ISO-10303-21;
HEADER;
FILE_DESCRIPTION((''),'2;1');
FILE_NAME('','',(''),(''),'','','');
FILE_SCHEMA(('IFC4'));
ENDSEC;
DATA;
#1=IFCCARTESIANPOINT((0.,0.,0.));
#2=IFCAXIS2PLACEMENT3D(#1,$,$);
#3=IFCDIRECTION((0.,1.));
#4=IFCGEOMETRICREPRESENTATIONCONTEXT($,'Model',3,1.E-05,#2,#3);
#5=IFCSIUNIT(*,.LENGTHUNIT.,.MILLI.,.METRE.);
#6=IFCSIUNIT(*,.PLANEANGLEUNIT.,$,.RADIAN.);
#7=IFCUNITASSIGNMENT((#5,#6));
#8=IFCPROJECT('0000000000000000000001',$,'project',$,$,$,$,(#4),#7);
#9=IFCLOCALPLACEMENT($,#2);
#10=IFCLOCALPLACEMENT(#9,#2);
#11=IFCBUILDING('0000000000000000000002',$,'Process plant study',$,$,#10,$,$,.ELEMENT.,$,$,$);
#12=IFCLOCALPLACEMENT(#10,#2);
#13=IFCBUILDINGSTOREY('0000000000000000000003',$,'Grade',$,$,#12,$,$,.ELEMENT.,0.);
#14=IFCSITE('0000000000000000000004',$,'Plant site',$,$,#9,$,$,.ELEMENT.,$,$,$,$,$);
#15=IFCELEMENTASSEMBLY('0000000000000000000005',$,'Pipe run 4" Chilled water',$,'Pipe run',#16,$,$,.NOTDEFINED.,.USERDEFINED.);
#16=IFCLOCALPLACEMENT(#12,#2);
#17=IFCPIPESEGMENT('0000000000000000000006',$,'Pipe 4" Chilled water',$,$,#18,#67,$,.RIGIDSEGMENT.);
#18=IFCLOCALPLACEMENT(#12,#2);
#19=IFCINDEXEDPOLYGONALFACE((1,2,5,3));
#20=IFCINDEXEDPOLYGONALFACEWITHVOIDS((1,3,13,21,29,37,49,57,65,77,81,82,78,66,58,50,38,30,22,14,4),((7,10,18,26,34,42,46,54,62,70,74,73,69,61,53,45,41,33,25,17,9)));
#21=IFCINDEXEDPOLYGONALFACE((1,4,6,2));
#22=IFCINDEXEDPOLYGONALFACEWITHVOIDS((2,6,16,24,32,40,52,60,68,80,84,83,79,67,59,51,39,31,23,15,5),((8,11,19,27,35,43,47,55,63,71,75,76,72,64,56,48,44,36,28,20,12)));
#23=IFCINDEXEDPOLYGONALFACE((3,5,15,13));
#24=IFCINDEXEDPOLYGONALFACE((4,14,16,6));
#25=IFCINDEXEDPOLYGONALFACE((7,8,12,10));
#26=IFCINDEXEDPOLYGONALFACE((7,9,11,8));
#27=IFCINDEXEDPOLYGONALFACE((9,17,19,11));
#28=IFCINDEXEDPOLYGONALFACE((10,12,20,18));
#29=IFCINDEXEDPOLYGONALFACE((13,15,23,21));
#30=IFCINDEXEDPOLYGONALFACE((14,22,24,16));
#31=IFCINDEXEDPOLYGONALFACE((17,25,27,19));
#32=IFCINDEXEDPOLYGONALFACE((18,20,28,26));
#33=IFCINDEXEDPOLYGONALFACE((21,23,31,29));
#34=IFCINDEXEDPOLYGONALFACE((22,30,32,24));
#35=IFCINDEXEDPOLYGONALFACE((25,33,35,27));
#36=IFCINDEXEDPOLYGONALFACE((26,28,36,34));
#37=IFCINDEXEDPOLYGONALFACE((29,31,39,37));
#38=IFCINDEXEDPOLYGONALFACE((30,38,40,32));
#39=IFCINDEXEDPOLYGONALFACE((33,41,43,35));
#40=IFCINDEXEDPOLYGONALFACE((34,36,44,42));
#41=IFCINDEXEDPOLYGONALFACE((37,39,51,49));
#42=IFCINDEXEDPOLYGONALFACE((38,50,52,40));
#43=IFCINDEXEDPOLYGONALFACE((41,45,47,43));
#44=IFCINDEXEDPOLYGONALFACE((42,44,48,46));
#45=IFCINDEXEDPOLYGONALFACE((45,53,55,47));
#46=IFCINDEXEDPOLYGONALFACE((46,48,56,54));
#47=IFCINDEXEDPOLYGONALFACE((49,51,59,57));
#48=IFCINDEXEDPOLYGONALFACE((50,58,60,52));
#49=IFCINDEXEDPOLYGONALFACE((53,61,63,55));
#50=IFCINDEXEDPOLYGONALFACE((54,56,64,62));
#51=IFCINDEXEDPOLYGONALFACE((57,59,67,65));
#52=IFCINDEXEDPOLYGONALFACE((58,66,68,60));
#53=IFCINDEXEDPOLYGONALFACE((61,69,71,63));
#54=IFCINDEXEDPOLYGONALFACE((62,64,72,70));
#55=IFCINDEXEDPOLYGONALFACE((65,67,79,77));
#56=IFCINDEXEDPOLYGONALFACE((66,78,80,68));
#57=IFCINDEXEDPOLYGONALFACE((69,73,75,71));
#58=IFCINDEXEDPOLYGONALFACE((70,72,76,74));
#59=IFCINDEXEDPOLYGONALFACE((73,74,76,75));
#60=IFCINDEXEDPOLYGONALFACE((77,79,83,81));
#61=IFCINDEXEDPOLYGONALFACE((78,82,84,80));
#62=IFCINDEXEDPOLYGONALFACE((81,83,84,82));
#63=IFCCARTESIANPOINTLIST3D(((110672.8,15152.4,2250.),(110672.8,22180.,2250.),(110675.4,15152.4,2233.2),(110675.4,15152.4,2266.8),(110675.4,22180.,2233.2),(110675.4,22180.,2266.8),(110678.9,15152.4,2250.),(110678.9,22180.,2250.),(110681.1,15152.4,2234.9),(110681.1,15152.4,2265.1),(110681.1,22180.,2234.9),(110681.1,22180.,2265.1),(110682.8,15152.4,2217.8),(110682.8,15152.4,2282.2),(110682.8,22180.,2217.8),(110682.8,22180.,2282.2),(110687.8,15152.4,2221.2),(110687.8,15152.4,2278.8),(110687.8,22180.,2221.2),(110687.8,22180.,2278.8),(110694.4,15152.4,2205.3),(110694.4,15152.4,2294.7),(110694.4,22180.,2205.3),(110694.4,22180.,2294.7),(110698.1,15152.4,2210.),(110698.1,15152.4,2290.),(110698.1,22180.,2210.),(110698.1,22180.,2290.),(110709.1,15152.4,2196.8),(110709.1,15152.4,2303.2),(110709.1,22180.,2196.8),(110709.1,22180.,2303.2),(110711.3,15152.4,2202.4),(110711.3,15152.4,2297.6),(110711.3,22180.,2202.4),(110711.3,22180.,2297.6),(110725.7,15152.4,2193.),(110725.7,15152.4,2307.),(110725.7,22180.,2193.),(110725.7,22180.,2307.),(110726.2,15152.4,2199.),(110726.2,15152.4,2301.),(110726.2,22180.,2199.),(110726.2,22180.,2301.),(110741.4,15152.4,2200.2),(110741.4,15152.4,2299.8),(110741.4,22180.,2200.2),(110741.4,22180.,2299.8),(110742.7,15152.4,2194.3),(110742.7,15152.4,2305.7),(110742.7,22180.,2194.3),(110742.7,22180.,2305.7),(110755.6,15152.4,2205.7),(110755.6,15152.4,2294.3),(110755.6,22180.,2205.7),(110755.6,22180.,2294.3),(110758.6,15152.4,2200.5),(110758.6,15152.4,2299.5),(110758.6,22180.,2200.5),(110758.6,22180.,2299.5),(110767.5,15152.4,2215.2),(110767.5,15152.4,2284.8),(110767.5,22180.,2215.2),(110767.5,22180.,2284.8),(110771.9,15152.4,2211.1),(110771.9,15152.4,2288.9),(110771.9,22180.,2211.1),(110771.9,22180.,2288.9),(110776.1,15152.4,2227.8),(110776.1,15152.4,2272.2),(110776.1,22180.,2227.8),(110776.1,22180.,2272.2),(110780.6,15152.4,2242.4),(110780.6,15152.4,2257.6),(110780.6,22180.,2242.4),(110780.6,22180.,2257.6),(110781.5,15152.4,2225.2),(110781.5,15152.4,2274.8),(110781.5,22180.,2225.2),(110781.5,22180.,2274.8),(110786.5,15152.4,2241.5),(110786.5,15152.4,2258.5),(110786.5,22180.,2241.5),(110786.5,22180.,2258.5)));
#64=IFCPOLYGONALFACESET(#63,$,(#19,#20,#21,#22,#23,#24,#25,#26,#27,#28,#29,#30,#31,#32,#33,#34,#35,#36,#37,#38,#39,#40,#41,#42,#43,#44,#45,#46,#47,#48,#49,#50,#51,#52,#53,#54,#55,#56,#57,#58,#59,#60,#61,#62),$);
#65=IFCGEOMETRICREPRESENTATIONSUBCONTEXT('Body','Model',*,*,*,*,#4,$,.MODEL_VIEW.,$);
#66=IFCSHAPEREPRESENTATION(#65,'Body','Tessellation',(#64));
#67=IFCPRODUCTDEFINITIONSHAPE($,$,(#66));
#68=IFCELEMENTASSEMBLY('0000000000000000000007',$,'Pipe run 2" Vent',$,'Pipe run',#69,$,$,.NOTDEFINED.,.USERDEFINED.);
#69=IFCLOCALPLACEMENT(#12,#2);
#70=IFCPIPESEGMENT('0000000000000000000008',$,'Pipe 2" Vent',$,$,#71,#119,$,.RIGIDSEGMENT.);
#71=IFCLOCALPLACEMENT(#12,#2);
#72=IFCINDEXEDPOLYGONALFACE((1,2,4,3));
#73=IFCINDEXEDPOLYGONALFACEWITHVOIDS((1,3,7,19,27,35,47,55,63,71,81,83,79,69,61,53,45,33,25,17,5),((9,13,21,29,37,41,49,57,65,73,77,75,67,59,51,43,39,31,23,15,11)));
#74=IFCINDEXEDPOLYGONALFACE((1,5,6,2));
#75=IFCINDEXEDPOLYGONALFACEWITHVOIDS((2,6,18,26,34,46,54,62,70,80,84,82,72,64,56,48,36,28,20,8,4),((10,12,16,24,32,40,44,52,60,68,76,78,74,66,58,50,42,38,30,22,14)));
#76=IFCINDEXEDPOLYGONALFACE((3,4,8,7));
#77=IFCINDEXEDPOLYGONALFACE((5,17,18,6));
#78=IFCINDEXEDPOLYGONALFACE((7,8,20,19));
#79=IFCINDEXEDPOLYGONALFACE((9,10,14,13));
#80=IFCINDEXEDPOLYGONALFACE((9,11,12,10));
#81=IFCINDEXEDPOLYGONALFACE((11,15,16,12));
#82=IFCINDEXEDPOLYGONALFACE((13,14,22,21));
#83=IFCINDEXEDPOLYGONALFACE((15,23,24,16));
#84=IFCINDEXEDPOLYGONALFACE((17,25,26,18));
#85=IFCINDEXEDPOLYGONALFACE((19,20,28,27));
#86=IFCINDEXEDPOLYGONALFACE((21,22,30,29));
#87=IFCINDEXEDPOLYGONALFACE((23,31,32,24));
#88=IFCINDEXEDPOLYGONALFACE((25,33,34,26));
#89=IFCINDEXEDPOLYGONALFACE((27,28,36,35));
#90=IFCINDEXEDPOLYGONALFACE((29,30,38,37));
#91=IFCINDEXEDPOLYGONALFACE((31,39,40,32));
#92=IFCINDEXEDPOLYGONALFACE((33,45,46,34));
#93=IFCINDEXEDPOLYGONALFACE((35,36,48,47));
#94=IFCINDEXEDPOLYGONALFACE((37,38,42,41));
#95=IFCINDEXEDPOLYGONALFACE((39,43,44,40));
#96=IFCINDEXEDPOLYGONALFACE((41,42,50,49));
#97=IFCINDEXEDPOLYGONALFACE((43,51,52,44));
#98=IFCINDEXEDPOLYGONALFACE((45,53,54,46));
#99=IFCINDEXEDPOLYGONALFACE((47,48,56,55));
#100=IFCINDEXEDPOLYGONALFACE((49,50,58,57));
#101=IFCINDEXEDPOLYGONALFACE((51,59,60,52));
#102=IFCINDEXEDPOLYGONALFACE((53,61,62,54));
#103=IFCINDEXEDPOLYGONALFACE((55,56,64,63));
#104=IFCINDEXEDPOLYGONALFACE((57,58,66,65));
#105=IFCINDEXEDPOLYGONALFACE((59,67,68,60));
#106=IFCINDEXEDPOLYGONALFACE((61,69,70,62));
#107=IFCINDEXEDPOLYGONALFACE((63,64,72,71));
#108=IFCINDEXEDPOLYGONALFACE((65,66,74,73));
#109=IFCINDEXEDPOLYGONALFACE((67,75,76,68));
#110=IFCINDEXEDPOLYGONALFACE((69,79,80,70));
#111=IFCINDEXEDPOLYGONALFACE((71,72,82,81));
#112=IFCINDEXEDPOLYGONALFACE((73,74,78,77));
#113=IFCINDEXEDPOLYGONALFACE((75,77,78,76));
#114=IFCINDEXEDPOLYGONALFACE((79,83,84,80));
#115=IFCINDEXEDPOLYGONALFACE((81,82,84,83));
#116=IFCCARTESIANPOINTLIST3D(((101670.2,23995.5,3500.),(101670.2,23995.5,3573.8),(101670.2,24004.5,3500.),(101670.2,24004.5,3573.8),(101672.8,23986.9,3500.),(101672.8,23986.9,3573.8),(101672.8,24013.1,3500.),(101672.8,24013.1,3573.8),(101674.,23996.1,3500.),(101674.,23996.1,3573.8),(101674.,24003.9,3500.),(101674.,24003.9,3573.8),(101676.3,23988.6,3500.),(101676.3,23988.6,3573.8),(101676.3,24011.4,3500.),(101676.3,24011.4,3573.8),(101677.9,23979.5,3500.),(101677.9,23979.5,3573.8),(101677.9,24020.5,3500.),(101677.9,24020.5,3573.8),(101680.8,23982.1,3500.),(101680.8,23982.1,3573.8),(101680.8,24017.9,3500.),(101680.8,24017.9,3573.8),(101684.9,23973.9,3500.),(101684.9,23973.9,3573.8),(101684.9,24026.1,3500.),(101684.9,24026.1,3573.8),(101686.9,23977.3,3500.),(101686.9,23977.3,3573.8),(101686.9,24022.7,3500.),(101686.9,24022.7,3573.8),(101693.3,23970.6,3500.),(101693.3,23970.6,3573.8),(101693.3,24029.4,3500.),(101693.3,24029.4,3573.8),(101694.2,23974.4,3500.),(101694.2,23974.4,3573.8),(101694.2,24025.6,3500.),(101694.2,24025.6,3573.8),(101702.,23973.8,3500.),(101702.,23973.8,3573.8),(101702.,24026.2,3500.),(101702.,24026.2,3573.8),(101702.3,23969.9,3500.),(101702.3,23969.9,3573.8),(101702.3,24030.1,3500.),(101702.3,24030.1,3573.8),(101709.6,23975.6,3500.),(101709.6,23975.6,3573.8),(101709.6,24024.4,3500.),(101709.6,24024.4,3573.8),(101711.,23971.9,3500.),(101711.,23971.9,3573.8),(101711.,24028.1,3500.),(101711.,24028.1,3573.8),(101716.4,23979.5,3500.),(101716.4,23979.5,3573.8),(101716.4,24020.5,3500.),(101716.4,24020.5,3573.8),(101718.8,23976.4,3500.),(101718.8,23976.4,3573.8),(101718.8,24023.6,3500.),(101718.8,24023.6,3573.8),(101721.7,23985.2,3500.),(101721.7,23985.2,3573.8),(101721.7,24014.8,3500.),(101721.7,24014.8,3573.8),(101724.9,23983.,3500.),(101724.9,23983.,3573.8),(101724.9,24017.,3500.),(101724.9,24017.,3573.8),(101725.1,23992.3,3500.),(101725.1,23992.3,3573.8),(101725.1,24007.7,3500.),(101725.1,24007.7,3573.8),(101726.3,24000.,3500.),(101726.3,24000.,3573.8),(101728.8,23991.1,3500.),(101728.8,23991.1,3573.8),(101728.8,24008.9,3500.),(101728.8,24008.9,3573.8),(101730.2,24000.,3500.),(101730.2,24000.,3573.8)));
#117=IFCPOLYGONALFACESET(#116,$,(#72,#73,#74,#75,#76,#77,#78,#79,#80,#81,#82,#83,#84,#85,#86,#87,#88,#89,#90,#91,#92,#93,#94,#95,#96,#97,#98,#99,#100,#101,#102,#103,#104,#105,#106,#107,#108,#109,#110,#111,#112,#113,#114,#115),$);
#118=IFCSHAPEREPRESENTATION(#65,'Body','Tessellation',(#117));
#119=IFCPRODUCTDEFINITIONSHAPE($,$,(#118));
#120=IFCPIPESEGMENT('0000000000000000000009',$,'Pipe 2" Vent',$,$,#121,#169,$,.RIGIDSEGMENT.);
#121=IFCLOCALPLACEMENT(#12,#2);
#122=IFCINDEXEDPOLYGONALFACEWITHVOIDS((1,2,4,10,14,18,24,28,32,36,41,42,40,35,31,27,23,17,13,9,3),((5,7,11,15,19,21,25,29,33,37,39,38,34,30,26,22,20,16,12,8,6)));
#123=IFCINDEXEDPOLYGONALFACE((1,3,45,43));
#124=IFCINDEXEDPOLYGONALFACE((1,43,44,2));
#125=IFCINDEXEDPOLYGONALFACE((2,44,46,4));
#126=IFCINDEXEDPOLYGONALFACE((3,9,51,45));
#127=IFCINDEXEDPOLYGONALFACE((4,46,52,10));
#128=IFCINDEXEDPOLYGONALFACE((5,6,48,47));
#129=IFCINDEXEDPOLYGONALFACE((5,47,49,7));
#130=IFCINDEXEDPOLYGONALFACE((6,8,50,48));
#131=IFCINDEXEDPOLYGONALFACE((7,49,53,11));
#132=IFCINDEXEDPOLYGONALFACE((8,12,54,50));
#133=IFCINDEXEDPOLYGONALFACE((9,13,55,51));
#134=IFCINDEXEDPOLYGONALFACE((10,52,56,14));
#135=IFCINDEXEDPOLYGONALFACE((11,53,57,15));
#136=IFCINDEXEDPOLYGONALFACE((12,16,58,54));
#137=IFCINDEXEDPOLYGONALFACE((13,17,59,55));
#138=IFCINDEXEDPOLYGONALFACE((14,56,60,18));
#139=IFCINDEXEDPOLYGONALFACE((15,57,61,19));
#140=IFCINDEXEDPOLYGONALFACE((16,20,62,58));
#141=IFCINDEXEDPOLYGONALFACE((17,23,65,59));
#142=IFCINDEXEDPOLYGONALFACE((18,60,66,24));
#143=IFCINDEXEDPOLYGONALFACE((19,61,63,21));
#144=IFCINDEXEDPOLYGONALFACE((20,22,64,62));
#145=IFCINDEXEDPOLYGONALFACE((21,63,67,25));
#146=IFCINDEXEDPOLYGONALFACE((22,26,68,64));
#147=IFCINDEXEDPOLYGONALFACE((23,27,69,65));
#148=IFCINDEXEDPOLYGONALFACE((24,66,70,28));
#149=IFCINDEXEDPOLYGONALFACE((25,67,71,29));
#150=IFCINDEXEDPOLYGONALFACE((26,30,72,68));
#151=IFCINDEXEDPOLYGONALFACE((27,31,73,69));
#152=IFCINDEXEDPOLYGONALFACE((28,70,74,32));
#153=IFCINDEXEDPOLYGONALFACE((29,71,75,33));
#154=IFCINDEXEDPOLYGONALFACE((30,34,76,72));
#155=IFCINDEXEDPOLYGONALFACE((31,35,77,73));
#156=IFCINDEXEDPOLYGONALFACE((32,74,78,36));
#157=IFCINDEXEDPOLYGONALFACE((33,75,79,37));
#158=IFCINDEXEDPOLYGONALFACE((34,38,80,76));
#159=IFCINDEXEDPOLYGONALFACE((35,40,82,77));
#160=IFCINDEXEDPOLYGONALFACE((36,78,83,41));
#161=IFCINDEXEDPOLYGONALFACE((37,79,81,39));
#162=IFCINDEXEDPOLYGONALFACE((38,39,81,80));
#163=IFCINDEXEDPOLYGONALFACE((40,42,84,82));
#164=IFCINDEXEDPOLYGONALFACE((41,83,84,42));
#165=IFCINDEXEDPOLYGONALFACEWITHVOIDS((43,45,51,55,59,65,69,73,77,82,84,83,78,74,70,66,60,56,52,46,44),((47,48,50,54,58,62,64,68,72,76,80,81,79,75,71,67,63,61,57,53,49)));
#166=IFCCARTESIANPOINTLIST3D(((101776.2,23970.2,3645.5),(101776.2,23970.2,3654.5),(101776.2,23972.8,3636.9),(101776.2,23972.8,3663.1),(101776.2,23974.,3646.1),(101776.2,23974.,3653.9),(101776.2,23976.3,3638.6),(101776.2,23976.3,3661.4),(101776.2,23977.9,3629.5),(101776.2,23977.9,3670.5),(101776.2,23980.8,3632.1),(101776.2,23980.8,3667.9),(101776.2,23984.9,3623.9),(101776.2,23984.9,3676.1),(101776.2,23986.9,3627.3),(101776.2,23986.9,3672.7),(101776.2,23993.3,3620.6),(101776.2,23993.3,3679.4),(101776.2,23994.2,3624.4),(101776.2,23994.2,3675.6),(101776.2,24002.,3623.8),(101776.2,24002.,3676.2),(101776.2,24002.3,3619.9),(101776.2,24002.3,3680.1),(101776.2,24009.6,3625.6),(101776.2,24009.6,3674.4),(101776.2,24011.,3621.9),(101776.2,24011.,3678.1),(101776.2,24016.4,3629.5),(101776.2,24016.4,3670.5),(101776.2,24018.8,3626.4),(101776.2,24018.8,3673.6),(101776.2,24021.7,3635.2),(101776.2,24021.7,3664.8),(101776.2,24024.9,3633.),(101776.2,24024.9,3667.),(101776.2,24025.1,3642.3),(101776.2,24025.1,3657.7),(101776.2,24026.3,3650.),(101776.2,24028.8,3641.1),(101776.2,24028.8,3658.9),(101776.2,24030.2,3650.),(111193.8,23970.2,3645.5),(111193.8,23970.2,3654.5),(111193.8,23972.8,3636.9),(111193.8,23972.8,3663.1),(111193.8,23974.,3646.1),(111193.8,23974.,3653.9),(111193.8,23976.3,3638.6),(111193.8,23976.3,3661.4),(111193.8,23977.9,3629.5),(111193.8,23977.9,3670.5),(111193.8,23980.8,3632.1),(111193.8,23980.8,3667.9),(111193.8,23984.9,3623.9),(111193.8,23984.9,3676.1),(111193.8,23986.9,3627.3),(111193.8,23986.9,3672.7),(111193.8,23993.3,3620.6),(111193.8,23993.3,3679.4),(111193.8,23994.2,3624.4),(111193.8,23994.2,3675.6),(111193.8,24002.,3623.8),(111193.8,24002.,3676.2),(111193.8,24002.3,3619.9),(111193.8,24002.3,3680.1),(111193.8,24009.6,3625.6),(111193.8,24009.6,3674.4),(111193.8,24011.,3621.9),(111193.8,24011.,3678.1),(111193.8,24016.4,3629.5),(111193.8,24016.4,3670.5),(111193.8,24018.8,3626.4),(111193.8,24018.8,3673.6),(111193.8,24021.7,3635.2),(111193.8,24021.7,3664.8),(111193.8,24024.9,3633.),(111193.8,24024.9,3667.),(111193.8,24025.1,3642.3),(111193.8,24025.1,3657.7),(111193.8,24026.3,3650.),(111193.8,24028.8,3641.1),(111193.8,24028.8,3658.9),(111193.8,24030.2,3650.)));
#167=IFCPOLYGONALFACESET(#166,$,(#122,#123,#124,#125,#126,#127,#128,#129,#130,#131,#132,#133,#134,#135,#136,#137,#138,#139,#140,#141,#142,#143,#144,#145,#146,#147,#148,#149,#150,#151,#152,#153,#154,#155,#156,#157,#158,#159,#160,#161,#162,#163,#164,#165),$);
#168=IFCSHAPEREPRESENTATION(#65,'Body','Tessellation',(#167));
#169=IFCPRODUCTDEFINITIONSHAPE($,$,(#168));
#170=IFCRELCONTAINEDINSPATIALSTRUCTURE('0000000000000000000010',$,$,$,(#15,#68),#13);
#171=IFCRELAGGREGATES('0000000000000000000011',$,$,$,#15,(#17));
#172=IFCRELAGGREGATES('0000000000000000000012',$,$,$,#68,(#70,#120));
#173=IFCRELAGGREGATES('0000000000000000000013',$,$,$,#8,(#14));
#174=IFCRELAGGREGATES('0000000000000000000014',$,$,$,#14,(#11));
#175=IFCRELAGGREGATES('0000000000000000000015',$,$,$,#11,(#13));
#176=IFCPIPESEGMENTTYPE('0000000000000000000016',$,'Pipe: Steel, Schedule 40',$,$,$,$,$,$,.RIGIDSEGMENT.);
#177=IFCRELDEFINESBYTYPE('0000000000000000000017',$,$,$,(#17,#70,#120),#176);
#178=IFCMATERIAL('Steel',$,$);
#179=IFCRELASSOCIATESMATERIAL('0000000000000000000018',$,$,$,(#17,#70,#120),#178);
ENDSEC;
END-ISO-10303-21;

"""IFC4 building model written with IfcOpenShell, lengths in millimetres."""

from ifc_helpers import new_model, si_unit, direction, frame, origin, origin_with_axes, origin_2d, place, context, subcontext, project, spatial, hollow_circle, extrude, material, type_object, element, aggregate, save


model = new_model("IFC4")

# Units and contexts
model_context = context("Model", 3, precision=1e-05, world=origin(), true_north=direction((0.0, 1.0)))
body_context = subcontext(model_context, "Body", "Model", "MODEL_VIEW")
ifc_project = project(units=[si_unit("LENGTHUNIT", "METRE", prefix="MILLI"), si_unit("PLANEANGLEUNIT", "RADIAN")], contexts=[model_context])

# Site, building, storey
site_placement = place(None, origin())
site = spatial("IfcSite", under=ifc_project, at=site_placement, Name="Plant site", CompositionType="ELEMENT")
building_placement = place(site_placement, origin())
building = spatial("IfcBuilding", under=site, at=building_placement, Name="Process plant study", CompositionType="ELEMENT")
storey_placement = place(building_placement, origin())
storey = spatial("IfcBuildingStorey", under=building, at=storey_placement, Name="Grade", CompositionType="ELEMENT", Elevation=0.0)

# Shared definitions
ifc_material = material(Name="Steel")
pipe_segment_type = type_object("IfcPipeSegmentType", Name="Pipe: Steel, Schedule 40", PredefinedType="RIGIDSEGMENT")

# Element assemblies, pipe segments
assembly_1_placement = place(storey_placement, origin_with_axes())
assembly_1 = element("IfcElementAssembly", 1, at=assembly_1_placement, inside=storey, Name="Pipe run 4\" Chilled water", ObjectType="Pipe run", AssemblyPlace="NOTDEFINED", PredefinedType="USERDEFINED")
pipe_segment_1_placement = place(storey_placement, origin_with_axes())
pipe_segment_1 = element("IfcPipeSegment", 2, at=pipe_segment_1_placement, type_object=pipe_segment_type, material=ifc_material, Name="Pipe 4\" Chilled water", PredefinedType="RIGIDSEGMENT", context=body_context, shape_type="SweptSolid", body=[
    extrude(hollow_circle(Radius=57.1, WallThickness=6.0, at=origin_2d()), frame((110730.0, 15152.4, 2250.0), z_axis=(0.0, 1.0, 0.0), x_axis=(-1.0, 0.0, 0.0)), (0.0, 0.0, 1.0), 7027.6),
])
assembly_2_placement = place(storey_placement, origin_with_axes())
assembly_2 = element("IfcElementAssembly", 3, at=assembly_2_placement, inside=storey, Name="Pipe run 2\" Vent", ObjectType="Pipe run", AssemblyPlace="NOTDEFINED", PredefinedType="USERDEFINED")
pipe_segment_2_placement = place(storey_placement, origin_with_axes())
pipe_segment_2 = element("IfcPipeSegment", 4, at=pipe_segment_2_placement, type_object=pipe_segment_type, material=ifc_material, Name="Pipe 2\" Vent", PredefinedType="RIGIDSEGMENT", context=body_context, shape_type="SweptSolid", body=[
    extrude(hollow_circle(Radius=30.2, WallThickness=3.9, at=origin_2d()), frame((101700.0, 24000.0, 3500.0), z_axis=(0.0, 0.0, 1.0), x_axis=(1.0, 0.0, 0.0)), (0.0, 0.0, 1.0), 73.8),
])
pipe_segment_3_placement = place(storey_placement, origin_with_axes())
pipe_segment_3 = element("IfcPipeSegment", 5, at=pipe_segment_3_placement, type_object=pipe_segment_type, material=ifc_material, Name="Pipe 2\" Vent", PredefinedType="RIGIDSEGMENT", context=body_context, shape_type="SweptSolid", body=[
    extrude(hollow_circle(Radius=30.2, WallThickness=3.9, at=origin_2d()), frame((101776.2, 24000.0, 3650.0), z_axis=(1.0, 0.0, 0.0), x_axis=(0.0, 1.0, 0.0)), (0.0, 0.0, 1.0), 9417.6),
])

aggregate(assembly_1, [pipe_segment_1])
aggregate(assembly_2, [pipe_segment_2, pipe_segment_3])

save(model, "model.ifc")
